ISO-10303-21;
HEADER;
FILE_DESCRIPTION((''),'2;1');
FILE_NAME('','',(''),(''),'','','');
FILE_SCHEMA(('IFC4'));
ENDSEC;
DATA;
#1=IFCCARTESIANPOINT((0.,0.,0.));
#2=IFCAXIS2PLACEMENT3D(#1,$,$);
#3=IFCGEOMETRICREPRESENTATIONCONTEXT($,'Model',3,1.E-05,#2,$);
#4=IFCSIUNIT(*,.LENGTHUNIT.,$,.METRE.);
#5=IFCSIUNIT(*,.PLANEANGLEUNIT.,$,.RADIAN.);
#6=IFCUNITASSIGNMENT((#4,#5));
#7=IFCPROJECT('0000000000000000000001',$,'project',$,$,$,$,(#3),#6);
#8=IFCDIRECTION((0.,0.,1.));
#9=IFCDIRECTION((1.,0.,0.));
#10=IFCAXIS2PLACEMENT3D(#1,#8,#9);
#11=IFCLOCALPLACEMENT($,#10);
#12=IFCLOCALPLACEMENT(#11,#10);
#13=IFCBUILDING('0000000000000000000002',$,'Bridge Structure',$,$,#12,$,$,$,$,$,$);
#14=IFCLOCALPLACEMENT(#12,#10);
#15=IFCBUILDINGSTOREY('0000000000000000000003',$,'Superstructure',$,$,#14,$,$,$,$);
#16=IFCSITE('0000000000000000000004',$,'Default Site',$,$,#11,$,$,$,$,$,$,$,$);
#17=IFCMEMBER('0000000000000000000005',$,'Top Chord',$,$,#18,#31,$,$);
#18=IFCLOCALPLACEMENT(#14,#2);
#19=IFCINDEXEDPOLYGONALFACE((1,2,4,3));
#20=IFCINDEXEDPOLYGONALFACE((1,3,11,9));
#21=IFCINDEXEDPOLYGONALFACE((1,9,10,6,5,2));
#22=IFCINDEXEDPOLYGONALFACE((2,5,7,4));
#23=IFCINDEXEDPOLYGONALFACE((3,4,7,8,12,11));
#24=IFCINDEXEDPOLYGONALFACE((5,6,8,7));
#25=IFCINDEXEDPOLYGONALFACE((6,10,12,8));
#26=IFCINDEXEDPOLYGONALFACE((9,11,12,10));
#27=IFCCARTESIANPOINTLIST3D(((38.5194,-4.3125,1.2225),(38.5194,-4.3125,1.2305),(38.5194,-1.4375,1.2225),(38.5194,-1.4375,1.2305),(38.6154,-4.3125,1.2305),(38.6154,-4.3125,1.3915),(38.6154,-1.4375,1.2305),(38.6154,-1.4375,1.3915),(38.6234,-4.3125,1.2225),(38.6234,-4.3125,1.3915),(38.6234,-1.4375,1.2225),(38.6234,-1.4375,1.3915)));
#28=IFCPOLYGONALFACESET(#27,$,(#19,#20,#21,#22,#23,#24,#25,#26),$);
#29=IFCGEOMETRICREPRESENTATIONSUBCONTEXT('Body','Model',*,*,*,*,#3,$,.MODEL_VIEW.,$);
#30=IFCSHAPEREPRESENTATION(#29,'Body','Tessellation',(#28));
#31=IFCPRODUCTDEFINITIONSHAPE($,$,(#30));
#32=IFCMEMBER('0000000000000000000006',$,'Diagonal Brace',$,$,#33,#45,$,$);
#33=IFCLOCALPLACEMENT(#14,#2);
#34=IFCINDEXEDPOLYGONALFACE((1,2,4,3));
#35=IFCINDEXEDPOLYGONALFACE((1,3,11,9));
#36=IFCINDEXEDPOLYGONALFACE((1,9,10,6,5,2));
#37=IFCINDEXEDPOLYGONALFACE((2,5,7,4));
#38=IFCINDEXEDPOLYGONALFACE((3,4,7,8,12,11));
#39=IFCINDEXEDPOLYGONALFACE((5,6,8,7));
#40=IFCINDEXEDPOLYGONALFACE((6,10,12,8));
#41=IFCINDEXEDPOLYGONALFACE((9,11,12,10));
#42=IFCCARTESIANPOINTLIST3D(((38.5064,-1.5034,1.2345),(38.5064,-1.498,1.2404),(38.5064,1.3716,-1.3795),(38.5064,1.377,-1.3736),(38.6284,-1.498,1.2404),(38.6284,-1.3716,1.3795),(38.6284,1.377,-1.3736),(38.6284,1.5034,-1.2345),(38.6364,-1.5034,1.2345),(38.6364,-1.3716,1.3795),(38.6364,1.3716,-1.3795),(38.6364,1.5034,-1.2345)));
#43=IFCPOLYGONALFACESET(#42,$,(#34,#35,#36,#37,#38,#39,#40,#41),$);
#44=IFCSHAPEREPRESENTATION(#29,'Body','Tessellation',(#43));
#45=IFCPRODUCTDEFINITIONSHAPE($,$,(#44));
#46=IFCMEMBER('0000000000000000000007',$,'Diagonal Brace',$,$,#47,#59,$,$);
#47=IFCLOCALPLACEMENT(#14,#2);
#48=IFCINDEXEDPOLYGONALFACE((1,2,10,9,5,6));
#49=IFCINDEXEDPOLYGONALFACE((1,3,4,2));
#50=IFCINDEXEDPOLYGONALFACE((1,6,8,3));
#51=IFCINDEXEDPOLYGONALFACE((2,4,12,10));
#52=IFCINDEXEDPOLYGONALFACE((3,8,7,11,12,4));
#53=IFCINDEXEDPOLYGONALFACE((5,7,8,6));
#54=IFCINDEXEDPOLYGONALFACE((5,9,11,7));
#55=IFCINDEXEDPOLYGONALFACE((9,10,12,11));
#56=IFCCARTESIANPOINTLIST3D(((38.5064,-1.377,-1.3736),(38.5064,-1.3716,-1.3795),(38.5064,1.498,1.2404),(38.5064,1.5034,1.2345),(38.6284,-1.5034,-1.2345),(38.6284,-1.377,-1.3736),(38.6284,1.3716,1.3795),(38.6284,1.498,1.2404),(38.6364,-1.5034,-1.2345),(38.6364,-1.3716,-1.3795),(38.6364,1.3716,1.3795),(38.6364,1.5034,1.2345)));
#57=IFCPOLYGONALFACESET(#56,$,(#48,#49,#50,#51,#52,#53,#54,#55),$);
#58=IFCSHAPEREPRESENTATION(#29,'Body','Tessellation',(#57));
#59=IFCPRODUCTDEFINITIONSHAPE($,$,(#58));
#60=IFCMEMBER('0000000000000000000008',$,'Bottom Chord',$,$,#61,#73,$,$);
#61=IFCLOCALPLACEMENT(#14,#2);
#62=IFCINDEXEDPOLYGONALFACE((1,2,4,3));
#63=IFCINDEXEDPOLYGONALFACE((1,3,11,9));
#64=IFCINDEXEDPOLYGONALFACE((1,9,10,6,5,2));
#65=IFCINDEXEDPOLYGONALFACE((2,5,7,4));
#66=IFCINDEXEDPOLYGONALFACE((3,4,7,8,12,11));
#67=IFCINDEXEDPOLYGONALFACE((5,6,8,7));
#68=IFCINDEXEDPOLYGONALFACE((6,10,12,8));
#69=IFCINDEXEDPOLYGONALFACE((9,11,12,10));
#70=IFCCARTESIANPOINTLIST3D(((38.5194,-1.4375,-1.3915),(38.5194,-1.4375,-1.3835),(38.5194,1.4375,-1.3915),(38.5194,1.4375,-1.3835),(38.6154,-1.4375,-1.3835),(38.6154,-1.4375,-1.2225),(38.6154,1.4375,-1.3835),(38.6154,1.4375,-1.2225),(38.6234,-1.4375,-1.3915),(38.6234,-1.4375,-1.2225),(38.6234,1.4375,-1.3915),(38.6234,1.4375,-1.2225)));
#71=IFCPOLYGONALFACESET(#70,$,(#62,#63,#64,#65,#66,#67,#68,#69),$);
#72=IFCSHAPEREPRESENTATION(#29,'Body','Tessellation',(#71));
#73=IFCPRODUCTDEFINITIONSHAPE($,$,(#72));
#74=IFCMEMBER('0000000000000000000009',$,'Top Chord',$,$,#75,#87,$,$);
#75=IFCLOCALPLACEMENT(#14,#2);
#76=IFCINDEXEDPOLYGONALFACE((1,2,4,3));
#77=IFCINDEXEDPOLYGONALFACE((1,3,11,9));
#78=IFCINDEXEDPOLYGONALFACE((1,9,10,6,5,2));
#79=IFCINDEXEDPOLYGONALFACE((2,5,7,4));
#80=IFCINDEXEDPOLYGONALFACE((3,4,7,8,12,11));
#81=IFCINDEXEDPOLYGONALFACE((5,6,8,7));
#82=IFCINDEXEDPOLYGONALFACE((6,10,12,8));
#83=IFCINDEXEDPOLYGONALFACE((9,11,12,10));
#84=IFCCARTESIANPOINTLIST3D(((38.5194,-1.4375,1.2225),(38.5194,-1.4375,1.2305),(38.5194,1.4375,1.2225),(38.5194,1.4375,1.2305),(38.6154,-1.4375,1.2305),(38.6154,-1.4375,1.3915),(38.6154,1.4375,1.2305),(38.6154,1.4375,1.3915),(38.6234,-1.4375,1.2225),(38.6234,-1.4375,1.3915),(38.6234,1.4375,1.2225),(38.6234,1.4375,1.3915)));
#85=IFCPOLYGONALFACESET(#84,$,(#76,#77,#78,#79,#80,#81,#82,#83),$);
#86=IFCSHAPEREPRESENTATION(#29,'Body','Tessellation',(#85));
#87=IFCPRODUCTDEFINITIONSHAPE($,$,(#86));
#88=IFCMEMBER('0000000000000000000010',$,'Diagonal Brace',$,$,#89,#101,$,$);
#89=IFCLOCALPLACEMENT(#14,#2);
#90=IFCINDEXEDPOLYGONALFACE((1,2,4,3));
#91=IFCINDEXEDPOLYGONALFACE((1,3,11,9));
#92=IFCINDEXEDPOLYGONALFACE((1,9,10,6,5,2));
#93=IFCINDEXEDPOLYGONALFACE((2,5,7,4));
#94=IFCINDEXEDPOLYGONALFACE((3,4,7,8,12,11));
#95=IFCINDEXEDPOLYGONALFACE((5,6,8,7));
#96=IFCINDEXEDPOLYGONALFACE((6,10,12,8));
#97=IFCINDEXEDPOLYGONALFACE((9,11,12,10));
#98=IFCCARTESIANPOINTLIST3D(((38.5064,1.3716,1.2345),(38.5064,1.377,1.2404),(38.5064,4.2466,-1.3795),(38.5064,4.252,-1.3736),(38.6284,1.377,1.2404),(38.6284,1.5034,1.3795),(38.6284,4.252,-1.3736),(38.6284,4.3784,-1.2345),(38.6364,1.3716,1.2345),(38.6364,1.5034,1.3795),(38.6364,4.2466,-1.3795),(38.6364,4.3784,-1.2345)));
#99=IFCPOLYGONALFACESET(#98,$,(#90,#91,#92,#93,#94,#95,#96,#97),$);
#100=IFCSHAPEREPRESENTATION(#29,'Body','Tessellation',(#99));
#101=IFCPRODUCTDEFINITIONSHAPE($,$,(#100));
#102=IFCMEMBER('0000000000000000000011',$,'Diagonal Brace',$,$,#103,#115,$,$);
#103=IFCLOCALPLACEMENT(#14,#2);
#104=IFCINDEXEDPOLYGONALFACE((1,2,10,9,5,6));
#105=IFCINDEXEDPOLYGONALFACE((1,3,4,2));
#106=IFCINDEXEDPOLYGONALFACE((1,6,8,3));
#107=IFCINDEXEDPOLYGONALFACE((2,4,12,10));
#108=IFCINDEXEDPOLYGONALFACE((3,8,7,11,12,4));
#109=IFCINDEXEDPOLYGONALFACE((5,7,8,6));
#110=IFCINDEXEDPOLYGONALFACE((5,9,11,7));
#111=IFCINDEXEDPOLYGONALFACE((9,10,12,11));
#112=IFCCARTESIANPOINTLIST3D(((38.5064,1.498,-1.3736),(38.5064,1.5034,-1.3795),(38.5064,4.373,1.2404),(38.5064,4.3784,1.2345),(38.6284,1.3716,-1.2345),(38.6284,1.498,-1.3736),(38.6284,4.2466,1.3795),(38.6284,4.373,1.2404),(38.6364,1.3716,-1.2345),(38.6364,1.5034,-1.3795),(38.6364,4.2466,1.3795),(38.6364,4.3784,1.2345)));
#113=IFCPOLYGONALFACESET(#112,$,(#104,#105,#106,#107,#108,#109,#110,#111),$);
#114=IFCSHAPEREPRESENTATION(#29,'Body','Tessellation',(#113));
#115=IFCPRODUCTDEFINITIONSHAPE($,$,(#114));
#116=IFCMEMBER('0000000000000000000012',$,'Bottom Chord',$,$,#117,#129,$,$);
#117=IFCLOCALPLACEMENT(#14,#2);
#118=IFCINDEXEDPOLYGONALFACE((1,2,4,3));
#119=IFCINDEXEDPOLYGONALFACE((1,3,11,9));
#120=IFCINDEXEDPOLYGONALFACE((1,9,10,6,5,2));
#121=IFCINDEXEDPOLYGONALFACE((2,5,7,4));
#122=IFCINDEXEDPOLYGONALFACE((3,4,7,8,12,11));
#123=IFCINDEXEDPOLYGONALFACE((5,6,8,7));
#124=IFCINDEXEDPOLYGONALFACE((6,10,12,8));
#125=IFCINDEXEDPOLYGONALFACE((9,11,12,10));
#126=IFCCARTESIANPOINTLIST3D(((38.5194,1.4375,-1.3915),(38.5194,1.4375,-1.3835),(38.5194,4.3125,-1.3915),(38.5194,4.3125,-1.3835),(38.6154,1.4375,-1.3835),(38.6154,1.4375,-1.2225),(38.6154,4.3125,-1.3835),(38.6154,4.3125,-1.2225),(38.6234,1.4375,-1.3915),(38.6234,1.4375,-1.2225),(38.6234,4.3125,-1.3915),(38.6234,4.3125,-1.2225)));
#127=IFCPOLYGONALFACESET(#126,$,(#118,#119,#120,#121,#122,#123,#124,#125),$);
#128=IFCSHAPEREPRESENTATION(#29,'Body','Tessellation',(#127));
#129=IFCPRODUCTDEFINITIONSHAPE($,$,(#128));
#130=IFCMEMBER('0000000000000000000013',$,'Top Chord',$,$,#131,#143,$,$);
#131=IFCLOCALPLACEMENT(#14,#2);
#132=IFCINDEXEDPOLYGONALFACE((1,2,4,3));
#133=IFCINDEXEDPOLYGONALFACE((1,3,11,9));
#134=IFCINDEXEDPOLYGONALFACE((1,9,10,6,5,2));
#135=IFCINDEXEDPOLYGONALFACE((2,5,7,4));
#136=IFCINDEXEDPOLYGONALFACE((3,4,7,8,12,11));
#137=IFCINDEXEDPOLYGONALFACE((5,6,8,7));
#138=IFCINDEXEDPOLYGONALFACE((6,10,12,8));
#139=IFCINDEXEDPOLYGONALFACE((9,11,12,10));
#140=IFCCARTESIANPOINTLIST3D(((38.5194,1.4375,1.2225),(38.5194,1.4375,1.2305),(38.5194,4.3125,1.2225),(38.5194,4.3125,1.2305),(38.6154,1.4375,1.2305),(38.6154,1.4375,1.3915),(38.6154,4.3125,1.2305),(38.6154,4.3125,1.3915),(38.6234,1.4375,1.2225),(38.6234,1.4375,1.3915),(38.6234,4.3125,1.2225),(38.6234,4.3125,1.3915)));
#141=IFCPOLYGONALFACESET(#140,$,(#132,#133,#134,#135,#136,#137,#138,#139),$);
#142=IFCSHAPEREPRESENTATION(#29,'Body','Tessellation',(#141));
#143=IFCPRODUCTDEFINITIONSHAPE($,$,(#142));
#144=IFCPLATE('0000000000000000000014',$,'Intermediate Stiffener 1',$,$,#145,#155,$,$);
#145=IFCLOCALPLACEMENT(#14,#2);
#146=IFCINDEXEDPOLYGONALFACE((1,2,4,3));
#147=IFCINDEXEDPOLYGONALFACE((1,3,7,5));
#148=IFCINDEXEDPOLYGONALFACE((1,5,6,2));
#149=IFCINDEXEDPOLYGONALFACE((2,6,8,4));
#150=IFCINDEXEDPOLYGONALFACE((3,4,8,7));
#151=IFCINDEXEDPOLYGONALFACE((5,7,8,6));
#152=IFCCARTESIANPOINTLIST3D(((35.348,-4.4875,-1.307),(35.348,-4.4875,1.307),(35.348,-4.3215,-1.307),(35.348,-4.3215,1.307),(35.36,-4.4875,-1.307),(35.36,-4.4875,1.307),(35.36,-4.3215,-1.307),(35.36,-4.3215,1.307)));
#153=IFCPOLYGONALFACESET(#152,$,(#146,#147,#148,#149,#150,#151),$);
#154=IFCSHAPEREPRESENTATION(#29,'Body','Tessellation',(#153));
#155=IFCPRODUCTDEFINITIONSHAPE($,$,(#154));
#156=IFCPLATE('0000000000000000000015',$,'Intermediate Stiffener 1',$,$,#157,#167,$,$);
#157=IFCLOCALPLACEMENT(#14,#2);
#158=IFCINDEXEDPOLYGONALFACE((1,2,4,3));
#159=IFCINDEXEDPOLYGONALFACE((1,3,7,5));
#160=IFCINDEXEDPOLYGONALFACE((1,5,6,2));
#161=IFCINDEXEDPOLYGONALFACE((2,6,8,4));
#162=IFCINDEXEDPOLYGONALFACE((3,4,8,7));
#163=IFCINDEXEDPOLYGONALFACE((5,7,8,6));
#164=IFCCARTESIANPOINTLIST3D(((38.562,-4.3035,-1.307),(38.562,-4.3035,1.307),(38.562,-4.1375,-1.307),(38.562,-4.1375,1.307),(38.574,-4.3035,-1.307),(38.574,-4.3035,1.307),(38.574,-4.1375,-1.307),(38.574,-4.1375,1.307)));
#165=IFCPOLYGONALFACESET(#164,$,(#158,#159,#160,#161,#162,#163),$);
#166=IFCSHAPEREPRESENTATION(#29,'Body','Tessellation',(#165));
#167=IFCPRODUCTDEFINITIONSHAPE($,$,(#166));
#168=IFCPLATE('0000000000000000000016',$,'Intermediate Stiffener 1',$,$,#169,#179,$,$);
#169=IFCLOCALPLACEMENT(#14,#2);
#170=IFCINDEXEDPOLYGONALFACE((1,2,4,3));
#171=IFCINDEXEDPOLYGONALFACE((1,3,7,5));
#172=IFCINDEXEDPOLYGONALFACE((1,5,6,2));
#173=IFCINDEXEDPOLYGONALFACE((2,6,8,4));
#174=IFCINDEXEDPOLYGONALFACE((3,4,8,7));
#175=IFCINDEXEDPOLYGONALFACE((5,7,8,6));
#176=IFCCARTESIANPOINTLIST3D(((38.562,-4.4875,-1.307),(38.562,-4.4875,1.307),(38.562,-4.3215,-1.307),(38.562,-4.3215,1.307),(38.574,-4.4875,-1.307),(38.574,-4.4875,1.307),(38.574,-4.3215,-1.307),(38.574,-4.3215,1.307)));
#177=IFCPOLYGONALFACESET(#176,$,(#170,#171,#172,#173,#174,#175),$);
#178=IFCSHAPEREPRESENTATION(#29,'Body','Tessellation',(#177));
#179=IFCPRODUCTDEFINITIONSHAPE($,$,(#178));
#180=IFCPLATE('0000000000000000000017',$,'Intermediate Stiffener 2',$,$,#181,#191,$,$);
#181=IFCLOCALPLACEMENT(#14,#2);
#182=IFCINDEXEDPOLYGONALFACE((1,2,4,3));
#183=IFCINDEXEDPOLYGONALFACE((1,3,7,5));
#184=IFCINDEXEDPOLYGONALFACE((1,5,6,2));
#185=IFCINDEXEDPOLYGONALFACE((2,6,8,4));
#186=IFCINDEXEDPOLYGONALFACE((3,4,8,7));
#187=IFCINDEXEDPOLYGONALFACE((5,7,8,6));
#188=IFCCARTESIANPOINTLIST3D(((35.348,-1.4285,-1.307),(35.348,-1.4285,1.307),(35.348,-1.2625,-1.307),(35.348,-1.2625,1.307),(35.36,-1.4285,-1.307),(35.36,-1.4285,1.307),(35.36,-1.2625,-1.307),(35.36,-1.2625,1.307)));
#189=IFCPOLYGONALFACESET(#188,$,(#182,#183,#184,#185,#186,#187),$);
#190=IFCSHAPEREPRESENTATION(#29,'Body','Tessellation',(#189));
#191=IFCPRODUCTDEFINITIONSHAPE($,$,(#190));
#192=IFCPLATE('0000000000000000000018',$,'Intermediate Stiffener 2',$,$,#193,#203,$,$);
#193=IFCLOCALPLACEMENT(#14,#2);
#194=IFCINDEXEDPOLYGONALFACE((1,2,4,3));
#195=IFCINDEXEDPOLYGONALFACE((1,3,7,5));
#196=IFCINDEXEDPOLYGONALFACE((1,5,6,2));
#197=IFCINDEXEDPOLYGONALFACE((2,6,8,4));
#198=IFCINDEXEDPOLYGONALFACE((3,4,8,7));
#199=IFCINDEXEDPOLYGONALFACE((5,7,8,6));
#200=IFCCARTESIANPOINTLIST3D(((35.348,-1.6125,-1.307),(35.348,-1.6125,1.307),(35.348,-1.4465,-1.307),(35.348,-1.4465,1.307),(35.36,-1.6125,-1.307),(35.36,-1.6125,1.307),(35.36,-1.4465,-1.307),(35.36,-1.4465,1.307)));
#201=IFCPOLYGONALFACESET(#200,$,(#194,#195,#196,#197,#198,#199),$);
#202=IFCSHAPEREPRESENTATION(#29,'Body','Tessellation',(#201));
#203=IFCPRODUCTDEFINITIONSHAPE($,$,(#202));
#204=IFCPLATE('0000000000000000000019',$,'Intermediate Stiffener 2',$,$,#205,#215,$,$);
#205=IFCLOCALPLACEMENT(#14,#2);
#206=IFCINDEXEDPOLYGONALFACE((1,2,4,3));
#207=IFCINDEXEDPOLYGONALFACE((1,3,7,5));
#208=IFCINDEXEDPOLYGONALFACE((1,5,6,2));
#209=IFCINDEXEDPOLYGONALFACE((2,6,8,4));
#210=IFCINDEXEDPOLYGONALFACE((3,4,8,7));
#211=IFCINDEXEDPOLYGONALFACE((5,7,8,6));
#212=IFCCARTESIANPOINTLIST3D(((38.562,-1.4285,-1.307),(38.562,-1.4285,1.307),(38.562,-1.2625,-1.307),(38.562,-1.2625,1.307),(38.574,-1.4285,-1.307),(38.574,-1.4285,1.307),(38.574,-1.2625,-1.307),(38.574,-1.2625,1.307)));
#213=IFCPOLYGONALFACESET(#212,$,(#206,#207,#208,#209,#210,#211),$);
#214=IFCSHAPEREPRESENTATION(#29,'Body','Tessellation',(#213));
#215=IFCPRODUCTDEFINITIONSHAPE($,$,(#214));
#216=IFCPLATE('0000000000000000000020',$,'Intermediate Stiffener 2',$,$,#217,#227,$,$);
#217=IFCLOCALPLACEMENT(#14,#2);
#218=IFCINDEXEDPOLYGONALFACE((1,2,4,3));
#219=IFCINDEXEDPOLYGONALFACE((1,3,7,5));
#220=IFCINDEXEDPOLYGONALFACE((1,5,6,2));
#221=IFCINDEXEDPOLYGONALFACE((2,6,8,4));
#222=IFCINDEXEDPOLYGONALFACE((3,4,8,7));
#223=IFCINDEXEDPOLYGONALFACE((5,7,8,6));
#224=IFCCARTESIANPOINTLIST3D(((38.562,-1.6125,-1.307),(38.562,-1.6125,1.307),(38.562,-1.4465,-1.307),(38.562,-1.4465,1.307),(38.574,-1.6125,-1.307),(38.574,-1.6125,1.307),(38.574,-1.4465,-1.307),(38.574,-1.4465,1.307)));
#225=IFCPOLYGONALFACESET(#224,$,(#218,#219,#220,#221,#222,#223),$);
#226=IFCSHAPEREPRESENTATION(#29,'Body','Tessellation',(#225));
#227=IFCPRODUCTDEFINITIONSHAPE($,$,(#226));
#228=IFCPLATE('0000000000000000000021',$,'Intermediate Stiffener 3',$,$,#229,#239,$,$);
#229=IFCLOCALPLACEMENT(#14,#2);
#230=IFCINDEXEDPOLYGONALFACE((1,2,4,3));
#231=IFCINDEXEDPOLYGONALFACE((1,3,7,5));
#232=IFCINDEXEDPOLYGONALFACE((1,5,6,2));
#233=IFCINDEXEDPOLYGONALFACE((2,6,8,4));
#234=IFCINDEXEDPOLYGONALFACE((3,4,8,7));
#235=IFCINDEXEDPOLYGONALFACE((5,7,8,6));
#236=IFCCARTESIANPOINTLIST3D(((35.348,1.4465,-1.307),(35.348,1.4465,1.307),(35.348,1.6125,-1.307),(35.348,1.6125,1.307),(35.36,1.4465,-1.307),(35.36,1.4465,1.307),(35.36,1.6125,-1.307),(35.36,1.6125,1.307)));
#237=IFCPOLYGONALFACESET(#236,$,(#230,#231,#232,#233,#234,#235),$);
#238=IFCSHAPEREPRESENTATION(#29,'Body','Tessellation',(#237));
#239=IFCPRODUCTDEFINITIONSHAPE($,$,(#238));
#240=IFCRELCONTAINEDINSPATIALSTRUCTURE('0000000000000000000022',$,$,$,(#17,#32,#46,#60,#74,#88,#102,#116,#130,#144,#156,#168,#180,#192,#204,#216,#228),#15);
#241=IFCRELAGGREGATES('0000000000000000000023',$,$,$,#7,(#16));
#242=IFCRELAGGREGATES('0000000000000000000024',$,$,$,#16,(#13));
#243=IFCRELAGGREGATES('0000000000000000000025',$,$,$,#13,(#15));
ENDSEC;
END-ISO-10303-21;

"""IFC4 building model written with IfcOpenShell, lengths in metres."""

from ifc_helpers import new_model, si_unit, frame, origin, origin_with_axes, origin_2d_with_axis, place, context, subcontext, project, spatial, rectangle, l_section, extrude, element, save


model = new_model("IFC4")

# Units and contexts
model_context = context("Model", 3, precision=1e-05, world=origin())
body_context = subcontext(model_context, "Body", "Model", "MODEL_VIEW")
ifc_project = project(units=[si_unit("LENGTHUNIT", "METRE"), si_unit("PLANEANGLEUNIT", "RADIAN")], contexts=[model_context])

# Site, building, storey
site_placement = place(None, origin_with_axes())
site = spatial("IfcSite", under=ifc_project, at=site_placement, Name="Default Site")
building_placement = place(site_placement, origin_with_axes())
building = spatial("IfcBuilding", under=site, at=building_placement, Name="Bridge Structure")
storey_placement = place(building_placement, origin_with_axes())
storey = spatial("IfcBuildingStorey", under=building, at=storey_placement, Name="Superstructure")

# Members
for number, where, z_axis, x_axis, name in (
    (1, (38.5714, -4.3125, 1.307), (0.0, 1.0, 0.0), (-1.0, 0.0, 0.0), "Top Chord"),
):
    element("IfcMember", number, at=place(storey_placement, frame(where, z_axis=z_axis, x_axis=x_axis)), inside=storey, Name=name, context=body_context, shape_type="SweptSolid", body=[
        extrude(l_section(Depth=0.169, Width=0.104, Thickness=0.008, at=origin_2d_with_axis()), origin_with_axes(), (0.0, 0.0, 1.0), 2.875),
    ])
for number, where, z_axis, x_axis, name in (
    (2, (38.5714, -1.4375, 1.307), (0.0, 0.739893, -0.672724), (-1.0, 0.0, 0.0), "Diagonal Brace"),
    (3, (38.5714, -1.4375, -1.307), (0.0, 0.739893, 0.672724), (-1.0, 0.0, 0.0), "Diagonal Brace"),
):
    element("IfcMember", number, at=place(storey_placement, frame(where, z_axis=z_axis, x_axis=x_axis)), inside=storey, Name=name, context=body_context, shape_type="SweptSolid", body=[
        extrude(l_section(Depth=0.196, Width=0.13, Thickness=0.008, at=origin_2d_with_axis()), origin_with_axes(), (0.0, 0.0, 1.0), 3.8857),
    ])
for number, where, z_axis, x_axis, name in (
    (4, (38.5714, -1.4375, -1.307), (0.0, 1.0, 0.0), (-1.0, 0.0, 0.0), "Bottom Chord"),
    (5, (38.5714, -1.4375, 1.307), (0.0, 1.0, 0.0), (-1.0, 0.0, 0.0), "Top Chord"),
):
    element("IfcMember", number, at=place(storey_placement, frame(where, z_axis=z_axis, x_axis=x_axis)), inside=storey, Name=name, context=body_context, shape_type="SweptSolid", body=[
        extrude(l_section(Depth=0.169, Width=0.104, Thickness=0.008, at=origin_2d_with_axis()), origin_with_axes(), (0.0, 0.0, 1.0), 2.875),
    ])
for number, where, z_axis, x_axis, name in (
    (6, (38.5714, 1.4375, 1.307), (0.0, 0.739893, -0.672724), (-1.0, 0.0, 0.0), "Diagonal Brace"),
    (7, (38.5714, 1.4375, -1.307), (0.0, 0.739893, 0.672724), (-1.0, 0.0, 0.0), "Diagonal Brace"),
):
    element("IfcMember", number, at=place(storey_placement, frame(where, z_axis=z_axis, x_axis=x_axis)), inside=storey, Name=name, context=body_context, shape_type="SweptSolid", body=[
        extrude(l_section(Depth=0.196, Width=0.13, Thickness=0.008, at=origin_2d_with_axis()), origin_with_axes(), (0.0, 0.0, 1.0), 3.8857),
    ])
for number, where, z_axis, x_axis, name in (
    (8, (38.5714, 1.4375, -1.307), (0.0, 1.0, 0.0), (-1.0, 0.0, 0.0), "Bottom Chord"),
    (9, (38.5714, 1.4375, 1.307), (0.0, 1.0, 0.0), (-1.0, 0.0, 0.0), "Top Chord"),
):
    element("IfcMember", number, at=place(storey_placement, frame(where, z_axis=z_axis, x_axis=x_axis)), inside=storey, Name=name, context=body_context, shape_type="SweptSolid", body=[
        extrude(l_section(Depth=0.169, Width=0.104, Thickness=0.008, at=origin_2d_with_axis()), origin_with_axes(), (0.0, 0.0, 1.0), 2.875),
    ])

# Plates
for number, where, z_axis, x_axis, name in (
    (10, (35.354, -4.4045, -1.307), (0.0, 0.0, 1.0), (1.0, 0.0, 0.0), "Intermediate Stiffener 1"),
    (11, (38.568, -4.2205, -1.307), (0.0, 0.0, 1.0), (1.0, 0.0, 0.0), "Intermediate Stiffener 1"),
    (12, (38.568, -4.4045, -1.307), (0.0, 0.0, 1.0), (1.0, 0.0, 0.0), "Intermediate Stiffener 1"),
    (13, (35.354, -1.3455, -1.307), (0.0, 0.0, 1.0), (1.0, 0.0, 0.0), "Intermediate Stiffener 2"),
    (14, (35.354, -1.5295, -1.307), (0.0, 0.0, 1.0), (1.0, 0.0, 0.0), "Intermediate Stiffener 2"),
    (15, (38.568, -1.3455, -1.307), (0.0, 0.0, 1.0), (1.0, 0.0, 0.0), "Intermediate Stiffener 2"),
    (16, (38.568, -1.5295, -1.307), (0.0, 0.0, 1.0), (1.0, 0.0, 0.0), "Intermediate Stiffener 2"),
    (17, (35.354, 1.5295, -1.307), (0.0, 0.0, 1.0), (1.0, 0.0, 0.0), "Intermediate Stiffener 3"),
):
    element("IfcPlate", number, at=place(storey_placement, frame(where, z_axis=z_axis, x_axis=x_axis)), inside=storey, Name=name, context=body_context, shape_type="SweptSolid", body=[
        extrude(rectangle(XDim=0.012, YDim=0.166, at=origin_2d_with_axis()), origin_with_axes(), (0.0, 0.0, 1.0), 2.614),
    ])

save(model, "model.ifc")
